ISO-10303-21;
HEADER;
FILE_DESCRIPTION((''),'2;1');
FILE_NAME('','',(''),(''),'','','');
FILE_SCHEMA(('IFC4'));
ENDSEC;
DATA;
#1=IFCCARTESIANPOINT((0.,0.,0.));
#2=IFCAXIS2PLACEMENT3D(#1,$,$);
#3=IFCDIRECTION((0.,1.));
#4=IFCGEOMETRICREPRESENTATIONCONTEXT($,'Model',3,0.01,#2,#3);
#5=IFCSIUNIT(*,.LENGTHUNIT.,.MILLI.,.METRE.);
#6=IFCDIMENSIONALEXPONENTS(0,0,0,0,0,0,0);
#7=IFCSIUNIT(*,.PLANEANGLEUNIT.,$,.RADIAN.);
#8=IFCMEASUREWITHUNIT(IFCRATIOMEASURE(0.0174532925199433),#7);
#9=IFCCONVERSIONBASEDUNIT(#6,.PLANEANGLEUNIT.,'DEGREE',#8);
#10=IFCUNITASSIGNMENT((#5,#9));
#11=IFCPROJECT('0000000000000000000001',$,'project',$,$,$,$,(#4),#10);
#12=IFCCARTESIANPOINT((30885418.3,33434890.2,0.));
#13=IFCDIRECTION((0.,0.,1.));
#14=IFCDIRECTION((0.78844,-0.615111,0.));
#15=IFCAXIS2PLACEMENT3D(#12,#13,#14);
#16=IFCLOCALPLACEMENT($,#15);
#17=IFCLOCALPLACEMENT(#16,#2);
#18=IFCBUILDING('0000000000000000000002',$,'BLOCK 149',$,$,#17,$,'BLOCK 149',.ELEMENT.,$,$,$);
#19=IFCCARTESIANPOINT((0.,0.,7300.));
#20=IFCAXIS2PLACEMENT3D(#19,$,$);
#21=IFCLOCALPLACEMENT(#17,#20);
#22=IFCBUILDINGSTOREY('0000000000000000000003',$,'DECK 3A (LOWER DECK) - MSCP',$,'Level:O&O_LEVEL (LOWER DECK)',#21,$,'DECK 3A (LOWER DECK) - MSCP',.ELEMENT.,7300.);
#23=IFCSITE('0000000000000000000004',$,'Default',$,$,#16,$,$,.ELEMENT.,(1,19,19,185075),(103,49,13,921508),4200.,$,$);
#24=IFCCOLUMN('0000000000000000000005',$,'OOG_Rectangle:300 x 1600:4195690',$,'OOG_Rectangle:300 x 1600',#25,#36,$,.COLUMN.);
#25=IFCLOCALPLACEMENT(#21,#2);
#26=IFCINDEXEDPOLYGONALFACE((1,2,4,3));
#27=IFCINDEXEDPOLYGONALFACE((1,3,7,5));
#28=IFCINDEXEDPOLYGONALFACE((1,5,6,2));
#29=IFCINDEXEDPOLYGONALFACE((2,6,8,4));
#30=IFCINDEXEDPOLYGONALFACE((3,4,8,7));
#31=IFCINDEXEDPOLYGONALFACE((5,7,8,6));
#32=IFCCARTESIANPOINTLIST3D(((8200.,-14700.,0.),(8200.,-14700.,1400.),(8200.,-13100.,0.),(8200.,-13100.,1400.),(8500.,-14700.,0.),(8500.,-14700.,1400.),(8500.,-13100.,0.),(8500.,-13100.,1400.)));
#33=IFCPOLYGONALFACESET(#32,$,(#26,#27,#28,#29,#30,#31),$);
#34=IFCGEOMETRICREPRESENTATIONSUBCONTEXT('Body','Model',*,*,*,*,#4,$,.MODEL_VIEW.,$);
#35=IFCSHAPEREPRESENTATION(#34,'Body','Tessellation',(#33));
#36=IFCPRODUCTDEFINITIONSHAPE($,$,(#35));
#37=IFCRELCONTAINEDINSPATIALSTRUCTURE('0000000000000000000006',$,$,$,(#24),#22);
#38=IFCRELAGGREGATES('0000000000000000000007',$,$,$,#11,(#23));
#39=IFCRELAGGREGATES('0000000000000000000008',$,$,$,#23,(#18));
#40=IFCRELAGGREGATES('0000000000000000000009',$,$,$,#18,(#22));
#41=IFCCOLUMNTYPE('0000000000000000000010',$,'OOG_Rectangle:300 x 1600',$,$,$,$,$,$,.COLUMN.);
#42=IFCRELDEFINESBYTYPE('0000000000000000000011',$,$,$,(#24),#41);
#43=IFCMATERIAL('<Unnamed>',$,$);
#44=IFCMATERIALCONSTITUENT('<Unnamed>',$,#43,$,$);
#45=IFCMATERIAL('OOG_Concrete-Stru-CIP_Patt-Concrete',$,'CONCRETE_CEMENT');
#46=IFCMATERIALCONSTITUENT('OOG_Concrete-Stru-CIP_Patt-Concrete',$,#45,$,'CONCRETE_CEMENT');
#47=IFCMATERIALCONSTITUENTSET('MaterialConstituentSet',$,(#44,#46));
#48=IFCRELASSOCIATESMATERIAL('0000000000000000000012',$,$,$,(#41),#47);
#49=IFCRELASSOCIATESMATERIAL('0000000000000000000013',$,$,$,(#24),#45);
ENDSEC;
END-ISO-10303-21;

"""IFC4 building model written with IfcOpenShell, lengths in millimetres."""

from ifc_helpers import new_model, entity, si_unit, converted_unit, direction, frame, origin, place, context, subcontext, project, spatial, indexed_curve, outline, extrude, source, transform, mapped, material, constituent, constituent_set, type_object, type_shapes, element, save


model = new_model("IFC4")

# Units and contexts
model_context = context("Model", 3, precision=0.01, world=origin(), true_north=direction((0.0, 1.0)))
body_context = subcontext(model_context, "Body", "Model", "MODEL_VIEW")
ifc_project = project(units=[si_unit("LENGTHUNIT", "METRE", prefix="MILLI"), converted_unit("PLANEANGLEUNIT", "DEGREE", entity("IfcRatioMeasure", 0.0174532925199433), si_unit("PLANEANGLEUNIT", "RADIAN"), dimensions=[0, 0, 0, 0, 0, 0, 0])], contexts=[model_context])

# Site, building, storey
site_placement = place(None, frame((30885418.3, 33434890.2, 0.0), z_axis=(0.0, 0.0, 1.0), x_axis=(0.78844, -0.615111, 0.0)))
site = spatial("IfcSite", under=ifc_project, at=site_placement, Name="Default", CompositionType="ELEMENT", RefLatitude=(1, 19, 19, 185075), RefLongitude=(103, 49, 13, 921508), RefElevation=4200.0)
building_placement = place(site_placement, origin())
building = spatial("IfcBuilding", under=site, at=building_placement, Name="BLOCK 149", LongName="BLOCK 149", CompositionType="ELEMENT")
storey_placement = place(building_placement, frame((0.0, 0.0, 7300.0)))
storey = spatial("IfcBuildingStorey", under=building, at=storey_placement, Name="DECK 3A (LOWER DECK) - MSCP", ObjectType="Level:O&O_LEVEL (LOWER DECK)", LongName="DECK 3A (LOWER DECK) - MSCP", CompositionType="ELEMENT", Elevation=7300.0)

# Column
ifc_material_1 = material(Name="OOG_Concrete-Stru-CIP_Patt-Concrete", Category="CONCRETE_CEMENT")
ifc_material_2 = material(Name="<Unnamed>")
ifc_constituent_1 = constituent(ifc_material_2, Name="<Unnamed>")
ifc_constituent_2 = constituent(ifc_material_1, Name="OOG_Concrete-Stru-CIP_Patt-Concrete", Category="CONCRETE_CEMENT")
ifc_constituent_set = constituent_set(constituents=[ifc_constituent_1, ifc_constituent_2], Name="MaterialConstituentSet")
column_type = type_object("IfcColumnType", Name="OOG_Rectangle:300 x 1600", PredefinedType="COLUMN", material=ifc_constituent_set)
shared_shape = source(origin(), body_context, "Body", "SweptSolid", [
    extrude(outline(indexed_curve([(-800.0, -150.0), (800.0, -150.0), (800.0, 150.0), (-800.0, 150.0), (-800.0, -150.0)], self_intersect=False)), frame((0.0, 0.0, 7300.0), z_axis=(0.0, 0.0, 1.0), x_axis=(0.0, -1.0, 0.0)), (0.0, 0.0, 1.0), 1400.0),
])
type_shapes(column_type, [shared_shape])
column_placement = place(storey_placement, frame((8350.0, -13900.0, -7300.0)))
element("IfcColumn", 1, at=column_placement, inside=storey, type_object=column_type, material=ifc_material_1, Name="OOG_Rectangle:300 x 1600:4195690", ObjectType="OOG_Rectangle:300 x 1600", PredefinedType="COLUMN", context=body_context, shape_type="MappedRepresentation", body=[
    mapped(shared_shape, transform((0.0, 0.0, 0.0), scale=1.0)),
])

save(model, "model.ifc")
